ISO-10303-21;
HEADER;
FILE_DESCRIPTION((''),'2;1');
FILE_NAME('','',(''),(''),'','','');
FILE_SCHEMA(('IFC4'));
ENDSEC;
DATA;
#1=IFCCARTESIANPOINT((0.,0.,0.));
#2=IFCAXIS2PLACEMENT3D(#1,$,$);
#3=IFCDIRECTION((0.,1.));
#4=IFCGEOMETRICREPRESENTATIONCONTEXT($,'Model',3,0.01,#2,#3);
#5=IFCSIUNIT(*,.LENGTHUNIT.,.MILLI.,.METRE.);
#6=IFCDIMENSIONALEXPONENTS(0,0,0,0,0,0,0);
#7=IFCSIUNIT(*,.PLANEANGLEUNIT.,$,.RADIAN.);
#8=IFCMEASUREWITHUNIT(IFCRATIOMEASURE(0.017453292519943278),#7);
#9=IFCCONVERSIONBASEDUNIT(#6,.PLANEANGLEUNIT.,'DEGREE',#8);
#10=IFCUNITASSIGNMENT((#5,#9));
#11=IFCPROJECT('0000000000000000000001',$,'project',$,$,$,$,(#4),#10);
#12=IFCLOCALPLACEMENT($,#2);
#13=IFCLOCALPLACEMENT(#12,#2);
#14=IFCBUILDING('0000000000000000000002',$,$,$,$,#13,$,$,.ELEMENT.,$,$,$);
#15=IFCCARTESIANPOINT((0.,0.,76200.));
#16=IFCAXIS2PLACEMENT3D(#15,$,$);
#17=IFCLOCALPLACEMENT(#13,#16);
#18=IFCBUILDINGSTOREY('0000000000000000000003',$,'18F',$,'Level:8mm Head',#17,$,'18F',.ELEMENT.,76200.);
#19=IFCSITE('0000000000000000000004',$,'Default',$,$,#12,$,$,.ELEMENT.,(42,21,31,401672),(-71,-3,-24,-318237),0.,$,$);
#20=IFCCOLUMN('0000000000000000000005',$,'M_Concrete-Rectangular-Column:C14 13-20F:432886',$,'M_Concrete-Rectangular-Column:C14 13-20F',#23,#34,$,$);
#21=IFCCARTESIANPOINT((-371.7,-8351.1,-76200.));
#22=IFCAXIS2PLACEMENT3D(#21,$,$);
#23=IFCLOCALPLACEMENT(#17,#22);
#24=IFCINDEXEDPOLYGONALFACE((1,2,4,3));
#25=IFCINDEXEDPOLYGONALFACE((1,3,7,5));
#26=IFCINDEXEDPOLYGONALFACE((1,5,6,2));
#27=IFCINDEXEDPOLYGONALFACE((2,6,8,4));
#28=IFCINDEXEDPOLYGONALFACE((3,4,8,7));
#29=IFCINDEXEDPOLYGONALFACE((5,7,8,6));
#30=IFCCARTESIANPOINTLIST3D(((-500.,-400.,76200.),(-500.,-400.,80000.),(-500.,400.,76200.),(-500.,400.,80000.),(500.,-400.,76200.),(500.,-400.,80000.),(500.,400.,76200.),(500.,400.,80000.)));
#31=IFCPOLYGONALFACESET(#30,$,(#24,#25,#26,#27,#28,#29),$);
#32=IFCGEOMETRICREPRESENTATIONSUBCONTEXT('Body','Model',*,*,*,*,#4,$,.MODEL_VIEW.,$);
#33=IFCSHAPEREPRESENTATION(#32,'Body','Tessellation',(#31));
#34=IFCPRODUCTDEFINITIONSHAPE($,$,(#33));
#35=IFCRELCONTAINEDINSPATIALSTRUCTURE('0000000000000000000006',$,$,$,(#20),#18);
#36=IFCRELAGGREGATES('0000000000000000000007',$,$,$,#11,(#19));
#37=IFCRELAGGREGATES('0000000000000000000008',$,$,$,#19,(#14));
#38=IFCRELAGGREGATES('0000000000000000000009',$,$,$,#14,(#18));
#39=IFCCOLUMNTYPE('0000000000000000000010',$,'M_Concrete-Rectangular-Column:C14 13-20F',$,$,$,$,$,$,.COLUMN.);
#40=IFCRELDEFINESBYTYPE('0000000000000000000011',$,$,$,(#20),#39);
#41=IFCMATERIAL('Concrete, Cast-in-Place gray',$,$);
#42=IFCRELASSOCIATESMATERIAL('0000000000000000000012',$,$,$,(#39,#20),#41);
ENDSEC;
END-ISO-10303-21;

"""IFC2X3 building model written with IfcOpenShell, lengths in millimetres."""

from ifc_helpers import new_model, entity, si_unit, converted_unit, direction, frame, origin, origin_2d_with_axis, place, context, subcontext, project, spatial, rectangle, extrude, source, transform, mapped, material, type_object, type_shapes, element, save


model = new_model("IFC2X3")

# Units and contexts
model_context = context("Model", 3, precision=0.01, world=origin(), true_north=direction((0.0, 1.0)))
body_context = subcontext(model_context, "Body", "Model", "MODEL_VIEW")
ifc_project = project(units=[si_unit("LENGTHUNIT", "METRE", prefix="MILLI"), converted_unit("PLANEANGLEUNIT", "DEGREE", entity("IfcRatioMeasure", 0.017453292519943278), si_unit("PLANEANGLEUNIT", "RADIAN"), dimensions=[0, 0, 0, 0, 0, 0, 0])], contexts=[model_context])

# Site, building, storey
site_placement = place(None, origin())
site = spatial("IfcSite", under=ifc_project, at=site_placement, Name="Default", CompositionType="ELEMENT", RefLatitude=(42, 21, 31, 401672), RefLongitude=(-71, -3, -24, -318237), RefElevation=0.0)
building_placement = place(site_placement, origin())
building = spatial("IfcBuilding", under=site, at=building_placement, CompositionType="ELEMENT")
storey_placement = place(building_placement, frame((0.0, 0.0, 76200.0)))
storey = spatial("IfcBuildingStorey", under=building, at=storey_placement, Name="18F", ObjectType="Level:8mm Head", LongName="18F", CompositionType="ELEMENT", Elevation=76200.0)

# Column
ifc_material_1 = material(Name="Concrete, Cast-in-Place gray")
column_type = type_object("IfcColumnType", Name="M_Concrete-Rectangular-Column:C14 13-20F", PredefinedType="COLUMN", material=ifc_material_1)
shared_shape = source(origin(), body_context, "Body", "SweptSolid", [
    extrude(rectangle(XDim=800.0, YDim=1000.0, at=origin_2d_with_axis()), frame((0.0, 0.0, 76200.0), z_axis=(0.0, 0.0, 1.0), x_axis=(0.0, -1.0, 0.0)), (0.0, 0.0, 1.0), 3800.0),
])
type_shapes(column_type, [shared_shape])
column_placement = place(storey_placement, frame((-371.7, -8351.1, -76200.0)))
element("IfcColumn", 1, at=column_placement, inside=storey, type_object=column_type, material=ifc_material_1, Name="M_Concrete-Rectangular-Column:C14 13-20F:432886", ObjectType="M_Concrete-Rectangular-Column:C14 13-20F", context=body_context, shape_type="MappedRepresentation", body=[
    mapped(shared_shape, transform((0.0, 0.0, 0.0), scale=1.0)),
])

save(model, "model.ifc")
